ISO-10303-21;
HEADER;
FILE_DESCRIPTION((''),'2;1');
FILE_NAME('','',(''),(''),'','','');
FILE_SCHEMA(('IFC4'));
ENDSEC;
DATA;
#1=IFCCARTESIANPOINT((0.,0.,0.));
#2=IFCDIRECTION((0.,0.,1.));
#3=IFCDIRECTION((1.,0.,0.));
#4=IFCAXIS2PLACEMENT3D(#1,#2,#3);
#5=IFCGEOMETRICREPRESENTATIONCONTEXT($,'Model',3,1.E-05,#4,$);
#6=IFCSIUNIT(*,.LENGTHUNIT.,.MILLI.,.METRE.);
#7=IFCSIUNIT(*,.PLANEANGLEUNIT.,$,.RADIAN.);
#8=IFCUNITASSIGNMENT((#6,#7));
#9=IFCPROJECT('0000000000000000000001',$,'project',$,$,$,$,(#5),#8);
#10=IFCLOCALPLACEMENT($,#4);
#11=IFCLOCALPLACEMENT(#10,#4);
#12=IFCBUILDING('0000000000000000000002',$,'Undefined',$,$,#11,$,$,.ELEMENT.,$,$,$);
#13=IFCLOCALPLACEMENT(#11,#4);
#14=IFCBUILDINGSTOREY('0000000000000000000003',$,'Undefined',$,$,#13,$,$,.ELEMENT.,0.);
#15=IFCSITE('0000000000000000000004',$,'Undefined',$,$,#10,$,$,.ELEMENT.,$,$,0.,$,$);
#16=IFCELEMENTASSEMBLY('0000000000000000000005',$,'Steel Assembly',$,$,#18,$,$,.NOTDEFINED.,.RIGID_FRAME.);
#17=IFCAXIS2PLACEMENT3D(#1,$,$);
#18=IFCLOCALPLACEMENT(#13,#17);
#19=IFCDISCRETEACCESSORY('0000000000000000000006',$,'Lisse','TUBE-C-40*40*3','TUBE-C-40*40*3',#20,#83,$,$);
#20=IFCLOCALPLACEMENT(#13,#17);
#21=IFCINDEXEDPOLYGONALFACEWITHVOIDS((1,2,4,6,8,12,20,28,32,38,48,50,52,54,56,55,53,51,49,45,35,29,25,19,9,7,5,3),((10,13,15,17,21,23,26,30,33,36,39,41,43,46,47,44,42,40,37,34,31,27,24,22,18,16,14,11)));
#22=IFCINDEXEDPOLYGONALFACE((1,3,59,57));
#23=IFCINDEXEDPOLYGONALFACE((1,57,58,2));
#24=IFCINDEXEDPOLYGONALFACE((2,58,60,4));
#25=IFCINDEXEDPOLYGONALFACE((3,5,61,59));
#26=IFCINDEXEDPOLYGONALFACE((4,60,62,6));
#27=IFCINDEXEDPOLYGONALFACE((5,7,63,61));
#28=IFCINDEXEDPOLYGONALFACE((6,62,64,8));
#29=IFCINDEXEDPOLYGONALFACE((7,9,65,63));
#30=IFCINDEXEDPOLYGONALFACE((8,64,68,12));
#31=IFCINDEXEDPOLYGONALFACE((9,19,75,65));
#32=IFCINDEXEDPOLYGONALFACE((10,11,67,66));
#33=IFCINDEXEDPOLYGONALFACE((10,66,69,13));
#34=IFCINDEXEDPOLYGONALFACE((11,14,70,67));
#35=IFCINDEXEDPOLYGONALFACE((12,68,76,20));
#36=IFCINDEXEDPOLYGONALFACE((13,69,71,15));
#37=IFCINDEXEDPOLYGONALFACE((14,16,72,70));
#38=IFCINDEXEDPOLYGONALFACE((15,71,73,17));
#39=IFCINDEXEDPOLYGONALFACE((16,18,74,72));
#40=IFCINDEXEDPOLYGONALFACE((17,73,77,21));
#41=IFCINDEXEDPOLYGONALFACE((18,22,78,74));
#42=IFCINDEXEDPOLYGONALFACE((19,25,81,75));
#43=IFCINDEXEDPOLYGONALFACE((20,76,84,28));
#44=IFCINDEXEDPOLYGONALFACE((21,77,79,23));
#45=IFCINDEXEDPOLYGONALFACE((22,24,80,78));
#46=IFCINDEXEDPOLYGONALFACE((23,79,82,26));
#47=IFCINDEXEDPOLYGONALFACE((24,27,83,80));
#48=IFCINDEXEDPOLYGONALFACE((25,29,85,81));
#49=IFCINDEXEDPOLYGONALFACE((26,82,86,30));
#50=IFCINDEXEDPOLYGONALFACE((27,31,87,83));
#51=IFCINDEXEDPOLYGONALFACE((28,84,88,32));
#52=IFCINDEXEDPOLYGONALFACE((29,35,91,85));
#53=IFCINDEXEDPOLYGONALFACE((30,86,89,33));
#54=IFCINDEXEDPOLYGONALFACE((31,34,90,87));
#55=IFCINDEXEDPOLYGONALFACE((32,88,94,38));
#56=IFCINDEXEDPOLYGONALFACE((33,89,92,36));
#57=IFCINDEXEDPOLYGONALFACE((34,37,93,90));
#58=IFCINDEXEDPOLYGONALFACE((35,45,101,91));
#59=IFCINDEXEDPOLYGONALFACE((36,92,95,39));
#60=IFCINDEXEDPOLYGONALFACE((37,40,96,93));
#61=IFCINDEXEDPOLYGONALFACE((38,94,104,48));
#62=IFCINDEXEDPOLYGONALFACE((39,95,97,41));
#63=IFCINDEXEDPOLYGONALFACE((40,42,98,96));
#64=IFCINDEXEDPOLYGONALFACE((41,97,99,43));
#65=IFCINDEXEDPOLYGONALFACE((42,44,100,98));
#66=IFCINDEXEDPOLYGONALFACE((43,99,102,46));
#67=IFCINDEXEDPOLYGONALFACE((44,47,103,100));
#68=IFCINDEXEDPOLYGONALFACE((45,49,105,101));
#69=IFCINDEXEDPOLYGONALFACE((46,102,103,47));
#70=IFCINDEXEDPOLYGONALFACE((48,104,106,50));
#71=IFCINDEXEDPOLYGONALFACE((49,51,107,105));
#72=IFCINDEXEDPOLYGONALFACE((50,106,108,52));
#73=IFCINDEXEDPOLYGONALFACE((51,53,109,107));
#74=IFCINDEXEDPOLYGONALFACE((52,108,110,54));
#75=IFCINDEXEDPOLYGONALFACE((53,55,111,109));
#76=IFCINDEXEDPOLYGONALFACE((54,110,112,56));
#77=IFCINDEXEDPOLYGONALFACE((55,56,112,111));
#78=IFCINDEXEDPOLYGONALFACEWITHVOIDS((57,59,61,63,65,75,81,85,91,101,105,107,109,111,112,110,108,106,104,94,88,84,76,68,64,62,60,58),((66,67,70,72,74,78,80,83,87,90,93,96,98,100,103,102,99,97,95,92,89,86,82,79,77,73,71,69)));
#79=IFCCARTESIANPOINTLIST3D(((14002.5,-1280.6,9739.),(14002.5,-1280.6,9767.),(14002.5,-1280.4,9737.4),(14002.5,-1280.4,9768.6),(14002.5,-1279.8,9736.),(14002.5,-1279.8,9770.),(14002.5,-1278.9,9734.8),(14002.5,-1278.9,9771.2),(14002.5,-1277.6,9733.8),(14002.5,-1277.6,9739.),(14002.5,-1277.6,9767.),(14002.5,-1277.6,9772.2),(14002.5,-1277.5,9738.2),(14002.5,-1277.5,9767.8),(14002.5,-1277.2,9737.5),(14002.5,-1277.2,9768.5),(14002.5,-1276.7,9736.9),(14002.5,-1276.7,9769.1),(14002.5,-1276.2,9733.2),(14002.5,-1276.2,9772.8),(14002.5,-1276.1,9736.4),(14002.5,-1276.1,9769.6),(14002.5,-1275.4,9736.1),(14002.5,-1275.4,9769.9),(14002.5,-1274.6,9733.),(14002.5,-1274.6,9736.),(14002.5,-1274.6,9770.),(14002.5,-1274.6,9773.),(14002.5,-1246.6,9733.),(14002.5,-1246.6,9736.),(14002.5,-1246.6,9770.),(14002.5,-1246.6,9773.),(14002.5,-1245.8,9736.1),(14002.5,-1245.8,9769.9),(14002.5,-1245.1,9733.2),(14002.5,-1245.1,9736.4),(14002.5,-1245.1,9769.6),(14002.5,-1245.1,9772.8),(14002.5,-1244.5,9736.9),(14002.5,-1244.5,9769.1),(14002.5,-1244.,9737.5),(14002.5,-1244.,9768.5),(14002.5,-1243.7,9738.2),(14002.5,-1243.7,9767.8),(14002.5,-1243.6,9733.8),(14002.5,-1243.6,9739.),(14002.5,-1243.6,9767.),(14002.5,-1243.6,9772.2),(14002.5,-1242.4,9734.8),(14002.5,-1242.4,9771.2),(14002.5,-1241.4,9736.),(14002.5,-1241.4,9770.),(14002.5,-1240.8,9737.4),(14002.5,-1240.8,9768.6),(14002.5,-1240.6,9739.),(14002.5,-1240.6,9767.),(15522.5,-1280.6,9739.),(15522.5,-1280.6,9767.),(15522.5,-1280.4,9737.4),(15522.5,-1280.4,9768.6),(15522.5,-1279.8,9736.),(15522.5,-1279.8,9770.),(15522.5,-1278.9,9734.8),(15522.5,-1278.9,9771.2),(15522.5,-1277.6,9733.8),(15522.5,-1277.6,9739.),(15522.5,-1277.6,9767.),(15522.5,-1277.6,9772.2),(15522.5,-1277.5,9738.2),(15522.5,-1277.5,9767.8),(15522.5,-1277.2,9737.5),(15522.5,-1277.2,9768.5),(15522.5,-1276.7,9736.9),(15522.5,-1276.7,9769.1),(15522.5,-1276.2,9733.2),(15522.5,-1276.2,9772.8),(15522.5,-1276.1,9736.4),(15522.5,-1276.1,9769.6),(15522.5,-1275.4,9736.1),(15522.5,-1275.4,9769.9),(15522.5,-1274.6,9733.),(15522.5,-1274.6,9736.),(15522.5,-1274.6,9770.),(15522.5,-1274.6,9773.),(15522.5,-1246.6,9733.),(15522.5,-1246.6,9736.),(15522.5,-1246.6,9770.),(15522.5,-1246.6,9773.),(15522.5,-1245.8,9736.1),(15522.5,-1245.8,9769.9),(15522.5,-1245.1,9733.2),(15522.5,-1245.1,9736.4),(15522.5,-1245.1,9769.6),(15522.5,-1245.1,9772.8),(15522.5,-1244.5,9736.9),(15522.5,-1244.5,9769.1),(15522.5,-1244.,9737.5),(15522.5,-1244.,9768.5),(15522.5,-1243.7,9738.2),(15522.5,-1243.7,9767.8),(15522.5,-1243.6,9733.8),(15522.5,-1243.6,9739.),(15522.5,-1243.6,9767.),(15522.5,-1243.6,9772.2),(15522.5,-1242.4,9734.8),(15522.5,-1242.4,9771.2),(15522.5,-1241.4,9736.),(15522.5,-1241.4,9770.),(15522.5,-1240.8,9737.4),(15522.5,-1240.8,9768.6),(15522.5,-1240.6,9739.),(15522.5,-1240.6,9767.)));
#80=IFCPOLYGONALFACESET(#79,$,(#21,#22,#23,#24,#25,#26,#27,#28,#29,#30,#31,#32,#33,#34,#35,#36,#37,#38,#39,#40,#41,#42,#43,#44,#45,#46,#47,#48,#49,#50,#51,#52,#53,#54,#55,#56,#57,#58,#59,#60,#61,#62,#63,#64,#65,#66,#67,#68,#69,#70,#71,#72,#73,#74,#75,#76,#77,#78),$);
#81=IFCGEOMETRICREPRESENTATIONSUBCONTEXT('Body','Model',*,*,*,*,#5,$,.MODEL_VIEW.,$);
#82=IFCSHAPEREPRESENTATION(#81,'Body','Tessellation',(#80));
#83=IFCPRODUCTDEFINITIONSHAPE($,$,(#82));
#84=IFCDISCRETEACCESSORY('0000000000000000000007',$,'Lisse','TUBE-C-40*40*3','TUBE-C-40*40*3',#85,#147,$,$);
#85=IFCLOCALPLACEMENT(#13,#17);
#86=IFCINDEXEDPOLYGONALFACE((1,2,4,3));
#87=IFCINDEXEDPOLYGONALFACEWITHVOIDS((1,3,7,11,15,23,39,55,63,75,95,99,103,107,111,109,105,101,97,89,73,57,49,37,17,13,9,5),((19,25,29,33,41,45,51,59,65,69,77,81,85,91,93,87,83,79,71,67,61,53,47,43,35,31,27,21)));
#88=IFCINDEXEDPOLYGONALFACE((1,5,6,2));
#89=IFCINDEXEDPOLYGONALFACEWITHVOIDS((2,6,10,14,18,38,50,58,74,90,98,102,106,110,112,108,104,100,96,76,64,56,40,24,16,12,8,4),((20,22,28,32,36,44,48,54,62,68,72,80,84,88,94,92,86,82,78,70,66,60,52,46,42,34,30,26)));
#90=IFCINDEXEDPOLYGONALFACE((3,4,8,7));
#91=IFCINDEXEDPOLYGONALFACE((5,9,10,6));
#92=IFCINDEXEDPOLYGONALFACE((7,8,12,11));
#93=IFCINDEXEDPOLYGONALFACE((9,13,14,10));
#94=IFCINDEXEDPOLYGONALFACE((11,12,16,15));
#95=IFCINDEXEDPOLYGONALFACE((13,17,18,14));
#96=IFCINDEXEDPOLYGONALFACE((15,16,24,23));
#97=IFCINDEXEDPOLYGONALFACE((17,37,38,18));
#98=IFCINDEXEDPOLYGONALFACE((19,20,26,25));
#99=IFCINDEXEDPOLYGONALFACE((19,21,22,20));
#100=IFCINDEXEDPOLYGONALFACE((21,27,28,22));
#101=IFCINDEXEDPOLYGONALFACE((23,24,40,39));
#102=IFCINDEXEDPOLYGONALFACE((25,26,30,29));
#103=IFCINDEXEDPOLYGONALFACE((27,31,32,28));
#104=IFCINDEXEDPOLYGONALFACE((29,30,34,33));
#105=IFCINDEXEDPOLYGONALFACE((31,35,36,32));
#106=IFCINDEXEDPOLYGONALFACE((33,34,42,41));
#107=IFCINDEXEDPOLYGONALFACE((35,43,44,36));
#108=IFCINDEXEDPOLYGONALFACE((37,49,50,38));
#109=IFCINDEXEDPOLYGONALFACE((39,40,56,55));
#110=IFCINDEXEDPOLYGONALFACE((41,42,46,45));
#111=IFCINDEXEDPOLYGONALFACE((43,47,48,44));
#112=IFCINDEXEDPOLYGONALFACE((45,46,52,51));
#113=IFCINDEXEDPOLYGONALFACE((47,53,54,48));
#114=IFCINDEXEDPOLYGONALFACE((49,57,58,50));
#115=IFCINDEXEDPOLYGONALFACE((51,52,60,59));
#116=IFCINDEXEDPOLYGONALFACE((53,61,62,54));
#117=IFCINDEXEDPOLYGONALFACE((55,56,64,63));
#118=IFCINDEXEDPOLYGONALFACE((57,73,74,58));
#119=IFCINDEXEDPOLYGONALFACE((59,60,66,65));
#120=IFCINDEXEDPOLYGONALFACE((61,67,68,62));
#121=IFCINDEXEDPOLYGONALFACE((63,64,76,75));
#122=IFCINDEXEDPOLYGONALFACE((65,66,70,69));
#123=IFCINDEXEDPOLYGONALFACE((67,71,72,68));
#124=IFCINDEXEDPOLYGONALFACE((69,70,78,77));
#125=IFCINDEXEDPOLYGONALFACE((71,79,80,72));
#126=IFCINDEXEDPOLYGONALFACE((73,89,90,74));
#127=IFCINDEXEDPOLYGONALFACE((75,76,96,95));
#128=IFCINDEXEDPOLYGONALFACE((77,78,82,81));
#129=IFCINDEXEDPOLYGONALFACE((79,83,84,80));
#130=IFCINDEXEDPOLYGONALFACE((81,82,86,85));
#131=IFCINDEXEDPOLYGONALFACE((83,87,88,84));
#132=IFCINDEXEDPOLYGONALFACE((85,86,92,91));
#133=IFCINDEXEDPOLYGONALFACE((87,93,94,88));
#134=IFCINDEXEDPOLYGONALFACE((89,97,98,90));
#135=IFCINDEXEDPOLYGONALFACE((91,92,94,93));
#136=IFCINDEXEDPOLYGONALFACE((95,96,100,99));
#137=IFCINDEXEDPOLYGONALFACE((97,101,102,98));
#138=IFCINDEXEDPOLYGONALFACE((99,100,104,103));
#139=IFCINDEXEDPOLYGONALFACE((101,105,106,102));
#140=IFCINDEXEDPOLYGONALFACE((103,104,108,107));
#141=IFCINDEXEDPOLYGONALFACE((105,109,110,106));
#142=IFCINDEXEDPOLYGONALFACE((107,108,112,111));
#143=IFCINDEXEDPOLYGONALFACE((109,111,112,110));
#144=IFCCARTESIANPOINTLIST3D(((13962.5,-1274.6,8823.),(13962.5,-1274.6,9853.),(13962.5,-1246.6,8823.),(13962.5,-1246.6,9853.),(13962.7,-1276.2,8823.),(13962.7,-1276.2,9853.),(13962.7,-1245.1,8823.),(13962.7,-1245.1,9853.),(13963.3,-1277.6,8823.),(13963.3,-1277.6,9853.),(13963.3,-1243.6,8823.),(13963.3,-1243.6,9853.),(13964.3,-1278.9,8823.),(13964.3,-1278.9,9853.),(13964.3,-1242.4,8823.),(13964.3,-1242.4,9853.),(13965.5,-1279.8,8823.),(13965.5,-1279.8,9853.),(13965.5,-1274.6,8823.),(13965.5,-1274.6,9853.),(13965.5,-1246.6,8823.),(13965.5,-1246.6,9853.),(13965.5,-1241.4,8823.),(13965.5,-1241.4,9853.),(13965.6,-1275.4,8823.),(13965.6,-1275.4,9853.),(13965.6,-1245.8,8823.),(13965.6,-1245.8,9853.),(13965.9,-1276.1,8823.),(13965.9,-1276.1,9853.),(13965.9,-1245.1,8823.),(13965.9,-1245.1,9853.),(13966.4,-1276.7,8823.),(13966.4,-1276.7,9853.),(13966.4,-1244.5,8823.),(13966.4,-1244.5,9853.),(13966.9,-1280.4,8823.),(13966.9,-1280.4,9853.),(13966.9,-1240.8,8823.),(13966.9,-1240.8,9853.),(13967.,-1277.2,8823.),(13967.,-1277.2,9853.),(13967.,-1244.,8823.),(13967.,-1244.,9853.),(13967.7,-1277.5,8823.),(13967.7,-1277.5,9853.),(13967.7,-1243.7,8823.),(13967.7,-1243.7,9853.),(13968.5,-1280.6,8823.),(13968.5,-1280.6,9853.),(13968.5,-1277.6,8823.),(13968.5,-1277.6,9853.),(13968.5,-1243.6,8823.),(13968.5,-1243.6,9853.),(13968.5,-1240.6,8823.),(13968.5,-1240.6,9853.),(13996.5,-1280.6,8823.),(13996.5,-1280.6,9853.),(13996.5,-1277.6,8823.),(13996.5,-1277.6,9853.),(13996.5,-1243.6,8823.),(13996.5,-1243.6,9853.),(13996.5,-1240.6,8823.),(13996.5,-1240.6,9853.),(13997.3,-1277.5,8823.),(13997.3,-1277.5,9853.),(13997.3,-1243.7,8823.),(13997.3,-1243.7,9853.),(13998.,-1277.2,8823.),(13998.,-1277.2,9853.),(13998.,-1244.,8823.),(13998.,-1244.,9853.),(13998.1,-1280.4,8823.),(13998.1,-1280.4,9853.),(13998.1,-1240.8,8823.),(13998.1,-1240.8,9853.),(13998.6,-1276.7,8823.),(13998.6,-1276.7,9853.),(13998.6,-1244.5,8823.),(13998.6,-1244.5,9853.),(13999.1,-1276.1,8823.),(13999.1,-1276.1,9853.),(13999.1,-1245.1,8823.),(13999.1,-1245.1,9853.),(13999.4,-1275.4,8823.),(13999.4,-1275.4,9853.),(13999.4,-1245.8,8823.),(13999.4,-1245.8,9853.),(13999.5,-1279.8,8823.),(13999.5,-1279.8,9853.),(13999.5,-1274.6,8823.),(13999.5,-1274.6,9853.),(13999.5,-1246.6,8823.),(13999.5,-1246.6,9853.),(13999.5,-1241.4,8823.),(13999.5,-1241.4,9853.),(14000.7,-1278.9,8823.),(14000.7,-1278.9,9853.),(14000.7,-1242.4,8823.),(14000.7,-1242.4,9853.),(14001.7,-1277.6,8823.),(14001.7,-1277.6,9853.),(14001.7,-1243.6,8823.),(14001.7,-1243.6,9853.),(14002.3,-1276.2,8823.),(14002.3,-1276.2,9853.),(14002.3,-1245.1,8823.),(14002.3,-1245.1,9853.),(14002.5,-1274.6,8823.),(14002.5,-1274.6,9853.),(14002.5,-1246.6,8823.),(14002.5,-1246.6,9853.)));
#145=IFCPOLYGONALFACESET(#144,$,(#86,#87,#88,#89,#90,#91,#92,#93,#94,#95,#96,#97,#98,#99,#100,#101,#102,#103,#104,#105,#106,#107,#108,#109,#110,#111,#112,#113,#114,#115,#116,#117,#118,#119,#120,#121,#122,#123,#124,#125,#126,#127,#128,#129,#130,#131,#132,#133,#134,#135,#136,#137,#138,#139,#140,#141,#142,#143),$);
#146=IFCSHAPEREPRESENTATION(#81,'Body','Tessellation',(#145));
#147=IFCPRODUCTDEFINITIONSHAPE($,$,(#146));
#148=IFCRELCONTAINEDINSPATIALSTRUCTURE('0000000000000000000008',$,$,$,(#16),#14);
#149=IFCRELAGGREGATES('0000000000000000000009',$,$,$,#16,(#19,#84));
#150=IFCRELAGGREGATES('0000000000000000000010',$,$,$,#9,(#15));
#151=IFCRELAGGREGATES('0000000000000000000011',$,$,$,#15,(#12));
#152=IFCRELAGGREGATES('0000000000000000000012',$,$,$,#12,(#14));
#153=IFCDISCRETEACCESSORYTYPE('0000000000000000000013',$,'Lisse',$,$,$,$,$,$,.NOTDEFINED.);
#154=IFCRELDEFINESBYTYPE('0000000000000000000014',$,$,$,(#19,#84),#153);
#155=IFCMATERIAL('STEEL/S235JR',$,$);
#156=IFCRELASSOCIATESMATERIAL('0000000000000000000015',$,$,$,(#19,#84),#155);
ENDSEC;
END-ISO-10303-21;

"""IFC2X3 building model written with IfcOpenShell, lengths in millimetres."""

from ifc_helpers import new_model, si_unit, frame, origin_with_axes, origin_2d_with_axis, place, context, subcontext, project, spatial, hollow_rectangle, extrude, material, type_object, element, aggregate, save


model = new_model("IFC2X3")

# Units and contexts
model_context = context("Model", 3, precision=1e-05, world=origin_with_axes())
body_context = subcontext(model_context, "Body", "Model", "MODEL_VIEW")
ifc_project = project(units=[si_unit("LENGTHUNIT", "METRE", prefix="MILLI"), si_unit("PLANEANGLEUNIT", "RADIAN")], contexts=[model_context])

# Site, building, storey
site_placement = place(None, origin_with_axes())
site = spatial("IfcSite", under=ifc_project, at=site_placement, Name="Undefined", CompositionType="ELEMENT", RefElevation=0.0)
building_placement = place(site_placement, origin_with_axes())
building = spatial("IfcBuilding", under=site, at=building_placement, Name="Undefined", CompositionType="ELEMENT")
storey_placement = place(building_placement, origin_with_axes())
storey = spatial("IfcBuildingStorey", under=building, at=storey_placement, Name="Undefined", CompositionType="ELEMENT", Elevation=0.0)

# Shared definitions
ifc_material_1 = material(Name="STEEL/S235JR")

# Element assembly
assembly_1_placement = place(storey_placement, origin_with_axes())
assembly_1 = element("IfcElementAssembly", 1, at=assembly_1_placement, inside=storey, Name="Steel Assembly", AssemblyPlace="NOTDEFINED", PredefinedType="RIGID_FRAME")

# Discrete accessories
discrete_accessory_type_1 = type_object("IfcDiscreteAccessoryType", Name="Lisse")
discrete_accessory_1_placement = place(assembly_1_placement, frame((14002.5, -1260.6, 9753.0), z_axis=(0.0, 1.0, 0.0), x_axis=(1.0, 0.0, 0.0)))
discrete_accessory_1 = element("IfcDiscreteAccessory", 2, at=discrete_accessory_1_placement, type_object=discrete_accessory_type_1, material=ifc_material_1, Name="Lisse", Description="TUBE-C-40*40*3", ObjectType="TUBE-C-40*40*3", context=body_context, shape_type="SweptSolid", body=[
    extrude(hollow_rectangle(XDim=40.0, YDim=40.0, WallThickness=3.0, InnerFilletRadius=3.0, OuterFilletRadius=6.0, at=origin_2d_with_axis()), frame((1520.0, 0.0, 0.0), z_axis=(-1.0, 0.0, 0.0), x_axis=(0.0, -1.0, 0.0)), (0.0, 0.0, 1.0), 1520.0),
])
discrete_accessory_2_placement = place(assembly_1_placement, frame((13982.5, -1260.6, 9853.0), z_axis=(0.0, 1.0, 0.0), x_axis=(0.0, 0.0, -1.0)))
discrete_accessory_2 = element("IfcDiscreteAccessory", 3, at=discrete_accessory_2_placement, type_object=discrete_accessory_type_1, material=ifc_material_1, Name="Lisse", Description="TUBE-C-40*40*3", ObjectType="TUBE-C-40*40*3", context=body_context, shape_type="SweptSolid", body=[
    extrude(hollow_rectangle(XDim=40.0, YDim=40.0, WallThickness=3.0, InnerFilletRadius=3.0, OuterFilletRadius=6.0, at=origin_2d_with_axis()), frame((1030.0, 0.0, 0.0), z_axis=(-1.0, 0.0, 0.0), x_axis=(0.0, -1.0, 0.0)), (0.0, 0.0, 1.0), 1030.0),
])
aggregate(assembly_1, [discrete_accessory_1, discrete_accessory_2])

save(model, "model.ifc")
